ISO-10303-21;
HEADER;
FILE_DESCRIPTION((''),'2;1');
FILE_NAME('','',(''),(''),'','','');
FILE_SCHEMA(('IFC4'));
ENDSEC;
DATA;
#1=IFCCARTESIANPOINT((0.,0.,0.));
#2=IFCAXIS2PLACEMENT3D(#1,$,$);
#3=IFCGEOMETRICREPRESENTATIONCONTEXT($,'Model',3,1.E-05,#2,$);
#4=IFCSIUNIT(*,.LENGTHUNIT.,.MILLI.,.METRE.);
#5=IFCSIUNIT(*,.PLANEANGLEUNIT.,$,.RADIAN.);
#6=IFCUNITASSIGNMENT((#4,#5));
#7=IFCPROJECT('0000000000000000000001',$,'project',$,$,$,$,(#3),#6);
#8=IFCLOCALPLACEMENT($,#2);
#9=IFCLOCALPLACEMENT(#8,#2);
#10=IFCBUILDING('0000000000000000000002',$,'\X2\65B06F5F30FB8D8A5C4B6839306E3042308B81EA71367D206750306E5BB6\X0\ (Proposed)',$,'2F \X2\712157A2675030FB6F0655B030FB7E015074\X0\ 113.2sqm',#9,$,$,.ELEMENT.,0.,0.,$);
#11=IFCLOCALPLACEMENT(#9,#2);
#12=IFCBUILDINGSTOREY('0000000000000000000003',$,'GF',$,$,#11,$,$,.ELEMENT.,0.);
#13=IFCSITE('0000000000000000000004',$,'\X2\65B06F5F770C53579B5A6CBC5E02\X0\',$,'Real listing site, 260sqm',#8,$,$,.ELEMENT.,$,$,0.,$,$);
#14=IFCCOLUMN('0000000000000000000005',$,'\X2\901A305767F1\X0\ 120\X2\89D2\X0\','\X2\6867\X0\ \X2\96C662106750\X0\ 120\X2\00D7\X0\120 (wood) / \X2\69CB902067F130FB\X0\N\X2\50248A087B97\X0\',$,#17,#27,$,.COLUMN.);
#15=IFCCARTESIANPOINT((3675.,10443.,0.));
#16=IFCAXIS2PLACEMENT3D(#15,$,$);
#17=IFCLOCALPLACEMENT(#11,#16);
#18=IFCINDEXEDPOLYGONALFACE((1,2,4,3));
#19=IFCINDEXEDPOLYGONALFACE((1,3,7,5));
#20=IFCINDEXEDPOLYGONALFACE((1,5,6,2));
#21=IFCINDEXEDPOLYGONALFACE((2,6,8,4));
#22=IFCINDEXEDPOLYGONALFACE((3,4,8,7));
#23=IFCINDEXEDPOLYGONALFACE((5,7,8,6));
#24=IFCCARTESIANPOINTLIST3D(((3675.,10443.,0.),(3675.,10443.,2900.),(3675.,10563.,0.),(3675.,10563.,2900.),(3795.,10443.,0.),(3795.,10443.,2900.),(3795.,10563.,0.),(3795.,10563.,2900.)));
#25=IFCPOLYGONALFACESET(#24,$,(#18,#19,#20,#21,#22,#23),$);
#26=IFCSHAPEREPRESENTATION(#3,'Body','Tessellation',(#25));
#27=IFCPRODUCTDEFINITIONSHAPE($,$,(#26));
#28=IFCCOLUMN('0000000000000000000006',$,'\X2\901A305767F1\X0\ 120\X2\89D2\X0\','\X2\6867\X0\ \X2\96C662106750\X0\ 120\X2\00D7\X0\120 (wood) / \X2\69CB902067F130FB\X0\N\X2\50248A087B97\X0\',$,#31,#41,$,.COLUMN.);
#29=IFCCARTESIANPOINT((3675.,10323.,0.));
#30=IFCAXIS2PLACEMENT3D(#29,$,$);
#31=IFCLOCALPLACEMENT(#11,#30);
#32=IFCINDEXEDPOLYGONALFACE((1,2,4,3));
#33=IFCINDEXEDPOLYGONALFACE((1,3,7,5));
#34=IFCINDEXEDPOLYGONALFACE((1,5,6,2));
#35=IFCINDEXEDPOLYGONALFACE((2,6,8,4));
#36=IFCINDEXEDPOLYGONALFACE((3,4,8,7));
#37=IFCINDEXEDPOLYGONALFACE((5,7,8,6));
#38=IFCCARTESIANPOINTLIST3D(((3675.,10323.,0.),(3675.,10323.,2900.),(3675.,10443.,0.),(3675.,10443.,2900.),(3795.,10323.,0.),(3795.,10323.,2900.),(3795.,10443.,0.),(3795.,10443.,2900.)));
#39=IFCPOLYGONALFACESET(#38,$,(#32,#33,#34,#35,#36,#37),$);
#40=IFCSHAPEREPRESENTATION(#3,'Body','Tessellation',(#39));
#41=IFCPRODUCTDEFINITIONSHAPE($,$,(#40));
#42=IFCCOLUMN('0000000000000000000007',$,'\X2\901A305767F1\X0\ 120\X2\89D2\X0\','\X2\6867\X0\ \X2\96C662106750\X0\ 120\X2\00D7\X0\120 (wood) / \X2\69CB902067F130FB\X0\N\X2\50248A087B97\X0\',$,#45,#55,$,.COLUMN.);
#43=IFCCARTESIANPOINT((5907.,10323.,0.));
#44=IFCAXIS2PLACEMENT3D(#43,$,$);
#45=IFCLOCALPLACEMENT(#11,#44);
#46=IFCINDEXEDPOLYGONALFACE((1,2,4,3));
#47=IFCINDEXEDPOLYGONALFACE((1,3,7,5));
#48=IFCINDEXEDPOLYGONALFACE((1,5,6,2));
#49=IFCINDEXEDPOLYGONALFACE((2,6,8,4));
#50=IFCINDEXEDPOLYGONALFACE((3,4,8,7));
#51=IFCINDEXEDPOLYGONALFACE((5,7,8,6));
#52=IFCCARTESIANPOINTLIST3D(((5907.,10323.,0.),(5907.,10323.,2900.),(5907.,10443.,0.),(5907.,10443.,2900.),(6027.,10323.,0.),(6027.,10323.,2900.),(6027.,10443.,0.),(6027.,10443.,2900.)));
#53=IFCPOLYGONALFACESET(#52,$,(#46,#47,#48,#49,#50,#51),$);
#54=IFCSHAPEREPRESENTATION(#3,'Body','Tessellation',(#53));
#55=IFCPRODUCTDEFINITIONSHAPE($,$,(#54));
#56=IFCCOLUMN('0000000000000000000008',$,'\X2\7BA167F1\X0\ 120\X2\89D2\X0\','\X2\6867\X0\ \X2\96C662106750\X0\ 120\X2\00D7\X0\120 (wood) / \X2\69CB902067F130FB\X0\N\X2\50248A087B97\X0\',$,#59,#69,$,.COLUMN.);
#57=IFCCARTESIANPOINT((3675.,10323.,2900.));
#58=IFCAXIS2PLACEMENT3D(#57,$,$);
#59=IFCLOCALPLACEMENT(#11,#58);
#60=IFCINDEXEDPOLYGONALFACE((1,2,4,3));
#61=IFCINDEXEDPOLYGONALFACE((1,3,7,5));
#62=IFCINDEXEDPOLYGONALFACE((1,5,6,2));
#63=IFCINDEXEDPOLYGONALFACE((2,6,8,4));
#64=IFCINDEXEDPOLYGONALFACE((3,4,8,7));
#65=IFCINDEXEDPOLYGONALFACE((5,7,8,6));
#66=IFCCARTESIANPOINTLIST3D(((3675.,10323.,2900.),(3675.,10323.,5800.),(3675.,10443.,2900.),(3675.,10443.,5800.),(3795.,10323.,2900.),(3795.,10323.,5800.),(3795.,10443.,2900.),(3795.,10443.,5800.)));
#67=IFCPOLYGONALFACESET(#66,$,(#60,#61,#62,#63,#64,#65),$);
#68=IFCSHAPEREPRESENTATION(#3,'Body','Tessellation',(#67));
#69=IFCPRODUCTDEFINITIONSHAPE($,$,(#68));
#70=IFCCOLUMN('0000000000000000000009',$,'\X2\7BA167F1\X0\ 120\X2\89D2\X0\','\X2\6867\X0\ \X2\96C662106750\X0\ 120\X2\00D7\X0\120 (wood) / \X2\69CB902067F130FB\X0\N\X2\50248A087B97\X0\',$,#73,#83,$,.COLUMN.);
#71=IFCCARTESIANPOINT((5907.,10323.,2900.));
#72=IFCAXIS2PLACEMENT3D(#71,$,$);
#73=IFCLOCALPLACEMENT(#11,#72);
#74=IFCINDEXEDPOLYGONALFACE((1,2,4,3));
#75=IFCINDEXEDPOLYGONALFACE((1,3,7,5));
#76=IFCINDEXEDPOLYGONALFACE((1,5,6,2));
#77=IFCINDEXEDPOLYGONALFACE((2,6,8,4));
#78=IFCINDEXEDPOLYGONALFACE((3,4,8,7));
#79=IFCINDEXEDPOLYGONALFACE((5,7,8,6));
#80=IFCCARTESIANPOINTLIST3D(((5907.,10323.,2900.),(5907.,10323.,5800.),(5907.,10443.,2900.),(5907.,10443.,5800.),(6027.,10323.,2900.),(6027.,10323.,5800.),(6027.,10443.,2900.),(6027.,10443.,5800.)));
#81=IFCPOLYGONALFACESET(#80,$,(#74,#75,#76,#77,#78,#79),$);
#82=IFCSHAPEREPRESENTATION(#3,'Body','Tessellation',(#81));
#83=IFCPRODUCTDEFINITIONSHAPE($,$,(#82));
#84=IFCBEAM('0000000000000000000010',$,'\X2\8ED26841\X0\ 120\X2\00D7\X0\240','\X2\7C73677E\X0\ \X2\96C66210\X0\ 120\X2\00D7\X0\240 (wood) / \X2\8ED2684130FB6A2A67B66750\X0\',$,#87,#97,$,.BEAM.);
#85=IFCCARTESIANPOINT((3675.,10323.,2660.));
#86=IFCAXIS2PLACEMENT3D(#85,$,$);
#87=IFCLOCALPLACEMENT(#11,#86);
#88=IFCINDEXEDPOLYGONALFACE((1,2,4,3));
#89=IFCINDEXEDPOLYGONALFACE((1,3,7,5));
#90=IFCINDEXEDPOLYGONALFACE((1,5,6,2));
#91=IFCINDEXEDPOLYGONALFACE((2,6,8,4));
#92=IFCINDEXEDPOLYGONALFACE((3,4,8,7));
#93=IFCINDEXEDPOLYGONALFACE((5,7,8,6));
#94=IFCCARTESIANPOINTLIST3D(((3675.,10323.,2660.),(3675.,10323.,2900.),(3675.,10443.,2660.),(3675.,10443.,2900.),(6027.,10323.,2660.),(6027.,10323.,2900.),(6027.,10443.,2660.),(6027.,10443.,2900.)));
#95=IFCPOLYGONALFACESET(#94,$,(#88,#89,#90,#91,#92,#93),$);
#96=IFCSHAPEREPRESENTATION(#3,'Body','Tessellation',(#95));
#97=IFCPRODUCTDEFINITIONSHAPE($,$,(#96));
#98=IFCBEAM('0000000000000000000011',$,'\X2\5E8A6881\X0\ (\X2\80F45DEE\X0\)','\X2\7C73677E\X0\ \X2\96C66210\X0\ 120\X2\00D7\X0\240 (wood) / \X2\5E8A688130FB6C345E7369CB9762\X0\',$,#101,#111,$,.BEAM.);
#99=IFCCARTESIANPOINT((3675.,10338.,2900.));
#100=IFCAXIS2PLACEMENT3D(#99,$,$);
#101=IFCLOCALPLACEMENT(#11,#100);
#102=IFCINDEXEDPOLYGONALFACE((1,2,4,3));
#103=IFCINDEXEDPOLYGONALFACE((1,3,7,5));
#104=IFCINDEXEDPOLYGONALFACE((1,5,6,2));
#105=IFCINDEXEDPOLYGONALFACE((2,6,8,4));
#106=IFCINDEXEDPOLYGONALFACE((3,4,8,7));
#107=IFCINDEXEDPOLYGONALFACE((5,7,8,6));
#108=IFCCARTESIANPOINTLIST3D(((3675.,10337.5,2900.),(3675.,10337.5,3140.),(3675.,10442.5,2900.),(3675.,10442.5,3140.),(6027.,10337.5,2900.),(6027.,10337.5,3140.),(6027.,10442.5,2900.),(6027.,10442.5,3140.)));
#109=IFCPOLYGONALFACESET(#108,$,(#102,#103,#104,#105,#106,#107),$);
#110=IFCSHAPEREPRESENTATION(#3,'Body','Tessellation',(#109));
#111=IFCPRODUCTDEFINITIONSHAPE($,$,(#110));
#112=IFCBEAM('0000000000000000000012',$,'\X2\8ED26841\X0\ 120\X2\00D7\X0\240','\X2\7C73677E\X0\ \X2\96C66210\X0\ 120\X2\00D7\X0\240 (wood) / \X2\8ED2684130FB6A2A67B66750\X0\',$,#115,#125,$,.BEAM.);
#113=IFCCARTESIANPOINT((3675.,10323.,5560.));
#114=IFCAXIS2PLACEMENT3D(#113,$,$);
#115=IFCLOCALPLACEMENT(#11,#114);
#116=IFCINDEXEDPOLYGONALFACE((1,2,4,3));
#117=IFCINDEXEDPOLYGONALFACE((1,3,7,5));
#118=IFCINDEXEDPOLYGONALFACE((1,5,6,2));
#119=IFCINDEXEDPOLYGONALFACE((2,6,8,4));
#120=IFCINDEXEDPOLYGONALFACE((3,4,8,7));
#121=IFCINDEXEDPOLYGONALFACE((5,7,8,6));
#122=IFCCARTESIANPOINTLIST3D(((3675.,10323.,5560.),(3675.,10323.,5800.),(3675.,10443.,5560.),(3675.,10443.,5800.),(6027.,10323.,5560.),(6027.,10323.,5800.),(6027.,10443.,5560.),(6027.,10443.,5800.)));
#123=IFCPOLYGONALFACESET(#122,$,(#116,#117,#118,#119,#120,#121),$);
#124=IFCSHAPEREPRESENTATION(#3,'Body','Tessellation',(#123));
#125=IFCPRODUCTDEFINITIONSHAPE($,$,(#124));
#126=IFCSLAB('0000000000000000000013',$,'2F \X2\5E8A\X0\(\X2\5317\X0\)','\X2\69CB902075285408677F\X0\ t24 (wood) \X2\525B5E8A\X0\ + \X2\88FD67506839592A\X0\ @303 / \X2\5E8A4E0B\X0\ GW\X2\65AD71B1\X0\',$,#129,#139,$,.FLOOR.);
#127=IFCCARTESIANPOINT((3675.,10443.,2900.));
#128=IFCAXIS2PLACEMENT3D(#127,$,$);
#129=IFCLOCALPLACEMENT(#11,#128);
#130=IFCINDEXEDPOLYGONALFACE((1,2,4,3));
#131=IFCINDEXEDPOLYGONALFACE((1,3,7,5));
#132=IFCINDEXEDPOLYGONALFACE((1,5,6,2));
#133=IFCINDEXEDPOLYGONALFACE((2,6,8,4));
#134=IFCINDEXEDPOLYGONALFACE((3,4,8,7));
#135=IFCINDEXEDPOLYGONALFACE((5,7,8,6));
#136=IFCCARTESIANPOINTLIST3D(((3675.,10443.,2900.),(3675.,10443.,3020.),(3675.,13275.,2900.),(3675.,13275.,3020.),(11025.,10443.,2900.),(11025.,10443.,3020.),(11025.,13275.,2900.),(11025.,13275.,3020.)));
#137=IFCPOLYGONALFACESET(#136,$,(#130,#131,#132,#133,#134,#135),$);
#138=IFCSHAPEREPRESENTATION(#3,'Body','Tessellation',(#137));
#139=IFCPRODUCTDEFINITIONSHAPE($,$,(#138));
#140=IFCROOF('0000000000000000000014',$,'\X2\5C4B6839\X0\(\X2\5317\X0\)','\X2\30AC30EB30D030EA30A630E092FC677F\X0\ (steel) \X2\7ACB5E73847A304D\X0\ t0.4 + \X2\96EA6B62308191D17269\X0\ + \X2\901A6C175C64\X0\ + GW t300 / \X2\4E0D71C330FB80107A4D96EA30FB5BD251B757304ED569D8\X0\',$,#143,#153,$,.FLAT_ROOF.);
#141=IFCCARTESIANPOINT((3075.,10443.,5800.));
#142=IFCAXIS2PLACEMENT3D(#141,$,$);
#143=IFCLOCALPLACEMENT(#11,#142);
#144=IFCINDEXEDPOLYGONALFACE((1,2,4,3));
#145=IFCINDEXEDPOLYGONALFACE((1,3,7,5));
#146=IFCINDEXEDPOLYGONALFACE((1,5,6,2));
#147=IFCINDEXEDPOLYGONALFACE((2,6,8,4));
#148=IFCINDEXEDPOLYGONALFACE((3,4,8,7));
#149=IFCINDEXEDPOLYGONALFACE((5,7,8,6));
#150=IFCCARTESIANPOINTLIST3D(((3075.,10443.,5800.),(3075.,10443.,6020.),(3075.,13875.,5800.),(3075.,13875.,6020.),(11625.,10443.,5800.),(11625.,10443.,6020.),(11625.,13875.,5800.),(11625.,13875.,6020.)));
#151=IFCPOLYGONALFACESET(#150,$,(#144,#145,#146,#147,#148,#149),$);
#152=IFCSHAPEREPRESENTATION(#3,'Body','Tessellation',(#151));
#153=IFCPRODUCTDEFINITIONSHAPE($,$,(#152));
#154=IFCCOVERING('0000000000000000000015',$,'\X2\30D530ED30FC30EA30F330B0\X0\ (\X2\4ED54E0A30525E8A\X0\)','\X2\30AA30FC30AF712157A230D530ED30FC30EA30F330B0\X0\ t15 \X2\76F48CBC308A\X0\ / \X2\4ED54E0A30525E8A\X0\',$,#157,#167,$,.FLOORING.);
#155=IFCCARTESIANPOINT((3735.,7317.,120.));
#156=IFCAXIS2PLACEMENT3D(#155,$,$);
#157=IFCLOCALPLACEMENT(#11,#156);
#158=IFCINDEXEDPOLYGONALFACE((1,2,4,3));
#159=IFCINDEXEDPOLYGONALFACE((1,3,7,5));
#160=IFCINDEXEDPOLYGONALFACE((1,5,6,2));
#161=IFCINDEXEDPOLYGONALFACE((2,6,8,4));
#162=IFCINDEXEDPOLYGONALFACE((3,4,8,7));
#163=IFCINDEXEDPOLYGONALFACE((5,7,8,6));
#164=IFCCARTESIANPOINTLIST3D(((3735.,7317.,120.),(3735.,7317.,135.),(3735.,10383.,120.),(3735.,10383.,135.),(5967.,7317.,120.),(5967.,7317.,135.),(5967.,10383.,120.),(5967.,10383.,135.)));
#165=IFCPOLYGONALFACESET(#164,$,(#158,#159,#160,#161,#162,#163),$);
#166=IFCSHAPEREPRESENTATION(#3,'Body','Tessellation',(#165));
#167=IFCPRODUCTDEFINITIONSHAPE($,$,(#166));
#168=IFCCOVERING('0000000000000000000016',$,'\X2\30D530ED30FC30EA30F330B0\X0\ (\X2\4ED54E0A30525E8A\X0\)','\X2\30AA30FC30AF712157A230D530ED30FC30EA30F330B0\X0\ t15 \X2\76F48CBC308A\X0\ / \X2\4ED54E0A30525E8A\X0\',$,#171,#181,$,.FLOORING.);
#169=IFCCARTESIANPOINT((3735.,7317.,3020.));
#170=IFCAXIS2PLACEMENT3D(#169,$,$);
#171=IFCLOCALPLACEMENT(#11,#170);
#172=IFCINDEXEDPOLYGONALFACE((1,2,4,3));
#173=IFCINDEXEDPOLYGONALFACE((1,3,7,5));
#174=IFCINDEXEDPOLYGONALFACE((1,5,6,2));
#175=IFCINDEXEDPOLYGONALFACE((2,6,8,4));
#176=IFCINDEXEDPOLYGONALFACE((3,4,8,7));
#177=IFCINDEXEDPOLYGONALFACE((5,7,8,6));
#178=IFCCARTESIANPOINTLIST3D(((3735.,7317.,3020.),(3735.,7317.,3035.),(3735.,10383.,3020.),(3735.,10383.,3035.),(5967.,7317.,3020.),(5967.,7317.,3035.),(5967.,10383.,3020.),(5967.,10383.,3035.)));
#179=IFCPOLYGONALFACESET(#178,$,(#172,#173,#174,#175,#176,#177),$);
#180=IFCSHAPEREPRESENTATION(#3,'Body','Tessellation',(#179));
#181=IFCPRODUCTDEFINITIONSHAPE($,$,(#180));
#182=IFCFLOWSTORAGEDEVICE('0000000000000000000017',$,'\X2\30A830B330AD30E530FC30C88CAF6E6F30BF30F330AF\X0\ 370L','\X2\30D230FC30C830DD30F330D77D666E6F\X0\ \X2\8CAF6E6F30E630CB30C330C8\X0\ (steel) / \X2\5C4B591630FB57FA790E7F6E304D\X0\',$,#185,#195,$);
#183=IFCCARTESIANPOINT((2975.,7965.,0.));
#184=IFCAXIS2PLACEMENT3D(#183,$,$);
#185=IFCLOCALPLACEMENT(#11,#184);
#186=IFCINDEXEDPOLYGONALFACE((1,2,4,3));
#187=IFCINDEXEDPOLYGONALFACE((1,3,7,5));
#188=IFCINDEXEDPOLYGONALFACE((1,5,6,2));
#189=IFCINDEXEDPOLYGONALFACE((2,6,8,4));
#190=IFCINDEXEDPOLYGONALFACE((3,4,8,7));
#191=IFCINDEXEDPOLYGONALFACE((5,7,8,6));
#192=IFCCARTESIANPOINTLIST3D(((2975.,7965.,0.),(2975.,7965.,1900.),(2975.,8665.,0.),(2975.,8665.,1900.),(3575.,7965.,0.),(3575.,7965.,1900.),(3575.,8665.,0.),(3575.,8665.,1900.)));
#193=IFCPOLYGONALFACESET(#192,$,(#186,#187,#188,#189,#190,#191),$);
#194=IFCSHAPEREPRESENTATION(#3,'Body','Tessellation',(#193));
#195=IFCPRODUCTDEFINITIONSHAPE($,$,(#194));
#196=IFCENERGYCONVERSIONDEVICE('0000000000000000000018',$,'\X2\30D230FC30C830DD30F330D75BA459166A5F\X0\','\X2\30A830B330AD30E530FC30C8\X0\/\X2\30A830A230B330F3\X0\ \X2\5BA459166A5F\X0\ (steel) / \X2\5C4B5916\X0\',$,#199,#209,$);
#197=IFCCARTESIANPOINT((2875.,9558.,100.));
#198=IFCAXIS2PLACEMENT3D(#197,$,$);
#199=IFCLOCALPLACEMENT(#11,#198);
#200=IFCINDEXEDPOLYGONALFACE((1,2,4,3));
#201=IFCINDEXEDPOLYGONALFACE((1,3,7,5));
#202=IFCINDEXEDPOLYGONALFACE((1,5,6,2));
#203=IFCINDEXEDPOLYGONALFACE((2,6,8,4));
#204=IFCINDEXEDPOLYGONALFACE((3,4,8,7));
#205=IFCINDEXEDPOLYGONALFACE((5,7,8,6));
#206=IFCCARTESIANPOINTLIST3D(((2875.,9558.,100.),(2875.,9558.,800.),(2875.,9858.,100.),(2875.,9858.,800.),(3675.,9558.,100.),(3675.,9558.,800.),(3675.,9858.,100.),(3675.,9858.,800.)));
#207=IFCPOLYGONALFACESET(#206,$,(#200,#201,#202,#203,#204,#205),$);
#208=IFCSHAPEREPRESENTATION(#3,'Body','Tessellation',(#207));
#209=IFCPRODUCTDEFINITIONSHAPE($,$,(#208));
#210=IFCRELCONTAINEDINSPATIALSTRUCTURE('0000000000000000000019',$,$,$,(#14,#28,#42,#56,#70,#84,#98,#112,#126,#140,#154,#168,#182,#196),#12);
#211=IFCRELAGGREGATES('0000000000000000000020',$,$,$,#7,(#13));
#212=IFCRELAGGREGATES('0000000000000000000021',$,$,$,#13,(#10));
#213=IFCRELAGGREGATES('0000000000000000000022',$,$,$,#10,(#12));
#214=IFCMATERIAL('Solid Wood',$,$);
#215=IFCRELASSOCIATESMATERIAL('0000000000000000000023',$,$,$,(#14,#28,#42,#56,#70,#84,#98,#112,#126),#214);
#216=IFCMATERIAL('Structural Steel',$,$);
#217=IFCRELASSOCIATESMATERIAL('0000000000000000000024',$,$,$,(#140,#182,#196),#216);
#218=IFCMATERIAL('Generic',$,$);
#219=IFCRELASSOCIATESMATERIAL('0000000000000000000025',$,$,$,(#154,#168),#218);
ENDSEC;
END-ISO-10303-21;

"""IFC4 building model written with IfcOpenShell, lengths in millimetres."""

from ifc_helpers import new_model, si_unit, frame, frame_2d, origin, place, context, project, spatial, rectangle, extrude, material, element, save


model = new_model("IFC4")

# Units and contexts
model_context = context("Model", 3, precision=1e-05, world=origin())
ifc_project = project(units=[si_unit("LENGTHUNIT", "METRE", prefix="MILLI"), si_unit("PLANEANGLEUNIT", "RADIAN")], contexts=[model_context])

# Site, building, storey
site_placement = place(None, origin())
site = spatial("IfcSite", under=ifc_project, at=site_placement, Name="新潟県南魚沼市", ObjectType="Real listing site, 260sqm", CompositionType="ELEMENT", RefElevation=0.0)
building_placement = place(site_placement, origin())
building = spatial("IfcBuilding", under=site, at=building_placement, Name="新潟・越屋根のある自然素材の家 (Proposed)", ObjectType="2F 無垢材・漆喰・縁側 113.2sqm", CompositionType="ELEMENT", ElevationOfRefHeight=0.0, ElevationOfTerrain=0.0)
storey_placement = place(building_placement, origin())
storey = spatial("IfcBuildingStorey", under=building, at=storey_placement, Name="GF", CompositionType="ELEMENT", Elevation=0.0)

# Columns
ifc_material_1 = material(Name="Solid Wood")
column_1_placement = place(storey_placement, frame((3675.0, 10443.0, 0.0)))
element("IfcColumn", 1, at=column_1_placement, inside=storey, material=ifc_material_1, Name="通し柱 120角", Description="桧 集成材 120×120 (wood) / 構造柱・N値計算", PredefinedType="COLUMN", context=model_context, shape_type="SweptSolid", body=[
    extrude(rectangle(XDim=120.0, YDim=120.0, at=frame_2d((60.0, 60.0))), frame((3675.0, 10443.0, 0.0)), (0.0, 0.0, 1.0), 2900.0),
])
column_2_placement = place(storey_placement, frame((3675.0, 10323.0, 0.0)))
element("IfcColumn", 2, at=column_2_placement, inside=storey, material=ifc_material_1, Name="通し柱 120角", Description="桧 集成材 120×120 (wood) / 構造柱・N値計算", PredefinedType="COLUMN", context=model_context, shape_type="SweptSolid", body=[
    extrude(rectangle(XDim=120.0, YDim=120.0, at=frame_2d((60.0, 60.0))), frame((3675.0, 10323.0, 0.0)), (0.0, 0.0, 1.0), 2900.0),
])
column_3_placement = place(storey_placement, frame((5907.0, 10323.0, 0.0)))
element("IfcColumn", 3, at=column_3_placement, inside=storey, material=ifc_material_1, Name="通し柱 120角", Description="桧 集成材 120×120 (wood) / 構造柱・N値計算", PredefinedType="COLUMN", context=model_context, shape_type="SweptSolid", body=[
    extrude(rectangle(XDim=120.0, YDim=120.0, at=frame_2d((60.0, 60.0))), frame((5907.0, 10323.0, 0.0)), (0.0, 0.0, 1.0), 2900.0),
])
column_4_placement = place(storey_placement, frame((3675.0, 10323.0, 2900.0)))
element("IfcColumn", 4, at=column_4_placement, inside=storey, material=ifc_material_1, Name="管柱 120角", Description="桧 集成材 120×120 (wood) / 構造柱・N値計算", PredefinedType="COLUMN", context=model_context, shape_type="SweptSolid", body=[
    extrude(rectangle(XDim=120.0, YDim=120.0, at=frame_2d((60.0, 60.0))), frame((3675.0, 10323.0, 2900.0)), (0.0, 0.0, 1.0), 2900.0),
])
column_5_placement = place(storey_placement, frame((5907.0, 10323.0, 2900.0)))
element("IfcColumn", 5, at=column_5_placement, inside=storey, material=ifc_material_1, Name="管柱 120角", Description="桧 集成材 120×120 (wood) / 構造柱・N値計算", PredefinedType="COLUMN", context=model_context, shape_type="SweptSolid", body=[
    extrude(rectangle(XDim=120.0, YDim=120.0, at=frame_2d((60.0, 60.0))), frame((5907.0, 10323.0, 2900.0)), (0.0, 0.0, 1.0), 2900.0),
])

# Beams
beam_1_placement = place(storey_placement, frame((3675.0, 10323.0, 2660.0)))
element("IfcBeam", 6, at=beam_1_placement, inside=storey, material=ifc_material_1, Name="軒桁 120×240", Description="米松 集成 120×240 (wood) / 軒桁・横架材", PredefinedType="BEAM", context=model_context, shape_type="SweptSolid", body=[
    extrude(rectangle(XDim=2352.0, YDim=120.0, at=frame_2d((1176.0, 60.0))), frame((3675.0, 10323.0, 2660.0)), (0.0, 0.0, 1.0), 240.0),
])
beam_2_placement = place(storey_placement, frame((3675.0, 10338.0, 2900.0)))
element("IfcBeam", 7, at=beam_2_placement, inside=storey, material=ifc_material_1, Name="床梁 (胴差)", Description="米松 集成 120×240 (wood) / 床梁・水平構面", PredefinedType="BEAM", context=model_context, shape_type="SweptSolid", body=[
    extrude(rectangle(XDim=2352.0, YDim=105.0, at=frame_2d((1176.0, 52.0))), frame((3675.0, 10338.0, 2900.0)), (0.0, 0.0, 1.0), 240.0),
])
beam_3_placement = place(storey_placement, frame((3675.0, 10323.0, 5560.0)))
element("IfcBeam", 8, at=beam_3_placement, inside=storey, material=ifc_material_1, Name="軒桁 120×240", Description="米松 集成 120×240 (wood) / 軒桁・横架材", PredefinedType="BEAM", context=model_context, shape_type="SweptSolid", body=[
    extrude(rectangle(XDim=2352.0, YDim=120.0, at=frame_2d((1176.0, 60.0))), frame((3675.0, 10323.0, 5560.0)), (0.0, 0.0, 1.0), 240.0),
])

# Slab
slab_1_placement = place(storey_placement, frame((3675.0, 10443.0, 2900.0)))
element("IfcSlab", 9, at=slab_1_placement, inside=storey, material=ifc_material_1, Name="2F 床(北)", Description="構造用合板 t24 (wood) 剛床 + 製材根太 @303 / 床下 GW断熱", PredefinedType="FLOOR", context=model_context, shape_type="SweptSolid", body=[
    extrude(rectangle(XDim=7350.0, YDim=2832.0, at=frame_2d((3675.0, 1416.0))), frame((3675.0, 10443.0, 2900.0)), (0.0, 0.0, 1.0), 120.0),
])

# Roof
ifc_material_2 = material(Name="Structural Steel")
for number, where, name in (
    (10, (3075.0, 10443.0, 5800.0), "屋根(北)"),
):
    element("IfcRoof", number, at=place(storey_placement, frame(where)), inside=storey, material=ifc_material_2, Name=name, Description="ガルバリウム鋼板 (steel) 立平葺き t0.4 + 雪止め金物 + 通気層 + GW t300 / 不燃・耐積雪・寒冷地仕様", PredefinedType="FLAT_ROOF", context=model_context, shape_type="SweptSolid", body=[
        extrude(rectangle(XDim=8550.0, YDim=3432.0, at=frame_2d((4275.0, 1716.0))), frame((3075.0, 10443.0, 5800.0)), (0.0, 0.0, 1.0), 220.0),
    ])

# Coverings
ifc_material_3 = material(Name="Generic")
covering_1_placement = place(storey_placement, frame((3735.0, 7317.0, 120.0)))
element("IfcCovering", 11, at=covering_1_placement, inside=storey, material=ifc_material_3, Name="フローリング (仕上げ床)", Description="オーク無垢フローリング t15 直貼り / 仕上げ床", PredefinedType="FLOORING", context=model_context, shape_type="SweptSolid", body=[
    extrude(rectangle(XDim=2232.0, YDim=3066.0, at=frame_2d((1116.0, 1533.0))), frame((3735.0, 7317.0, 120.0)), (0.0, 0.0, 1.0), 15.0),
])
covering_2_placement = place(storey_placement, frame((3735.0, 7317.0, 3020.0)))
element("IfcCovering", 12, at=covering_2_placement, inside=storey, material=ifc_material_3, Name="フローリング (仕上げ床)", Description="オーク無垢フローリング t15 直貼り / 仕上げ床", PredefinedType="FLOORING", context=model_context, shape_type="SweptSolid", body=[
    extrude(rectangle(XDim=2232.0, YDim=3066.0, at=frame_2d((1116.0, 1533.0))), frame((3735.0, 7317.0, 3020.0)), (0.0, 0.0, 1.0), 15.0),
])

# Flow storage device
flow_storage_device_placement = place(storey_placement, frame((2975.0, 7965.0, 0.0)))
element("IfcFlowStorageDevice", 13, at=flow_storage_device_placement, inside=storey, material=ifc_material_2, Name="エコキュート貯湯タンク 370L", Description="ヒートポンプ給湯 貯湯ユニット (steel) / 屋外・基礎置き", context=model_context, shape_type="SweptSolid", body=[
    extrude(rectangle(XDim=600.0, YDim=700.0, at=frame_2d((300.0, 350.0))), frame((2975.0, 7965.0, 0.0)), (0.0, 0.0, 1.0), 1900.0),
])

# Energy conversion device
energy_conversion_device_placement = place(storey_placement, frame((2875.0, 9558.0, 100.0)))
element("IfcEnergyConversionDevice", 14, at=energy_conversion_device_placement, inside=storey, material=ifc_material_2, Name="ヒートポンプ室外機", Description="エコキュート/エアコン 室外機 (steel) / 屋外", context=model_context, shape_type="SweptSolid", body=[
    extrude(rectangle(XDim=800.0, YDim=300.0, at=frame_2d((400.0, 150.0))), frame((2875.0, 9558.0, 100.0)), (0.0, 0.0, 1.0), 700.0),
])

save(model, "model.ifc")
